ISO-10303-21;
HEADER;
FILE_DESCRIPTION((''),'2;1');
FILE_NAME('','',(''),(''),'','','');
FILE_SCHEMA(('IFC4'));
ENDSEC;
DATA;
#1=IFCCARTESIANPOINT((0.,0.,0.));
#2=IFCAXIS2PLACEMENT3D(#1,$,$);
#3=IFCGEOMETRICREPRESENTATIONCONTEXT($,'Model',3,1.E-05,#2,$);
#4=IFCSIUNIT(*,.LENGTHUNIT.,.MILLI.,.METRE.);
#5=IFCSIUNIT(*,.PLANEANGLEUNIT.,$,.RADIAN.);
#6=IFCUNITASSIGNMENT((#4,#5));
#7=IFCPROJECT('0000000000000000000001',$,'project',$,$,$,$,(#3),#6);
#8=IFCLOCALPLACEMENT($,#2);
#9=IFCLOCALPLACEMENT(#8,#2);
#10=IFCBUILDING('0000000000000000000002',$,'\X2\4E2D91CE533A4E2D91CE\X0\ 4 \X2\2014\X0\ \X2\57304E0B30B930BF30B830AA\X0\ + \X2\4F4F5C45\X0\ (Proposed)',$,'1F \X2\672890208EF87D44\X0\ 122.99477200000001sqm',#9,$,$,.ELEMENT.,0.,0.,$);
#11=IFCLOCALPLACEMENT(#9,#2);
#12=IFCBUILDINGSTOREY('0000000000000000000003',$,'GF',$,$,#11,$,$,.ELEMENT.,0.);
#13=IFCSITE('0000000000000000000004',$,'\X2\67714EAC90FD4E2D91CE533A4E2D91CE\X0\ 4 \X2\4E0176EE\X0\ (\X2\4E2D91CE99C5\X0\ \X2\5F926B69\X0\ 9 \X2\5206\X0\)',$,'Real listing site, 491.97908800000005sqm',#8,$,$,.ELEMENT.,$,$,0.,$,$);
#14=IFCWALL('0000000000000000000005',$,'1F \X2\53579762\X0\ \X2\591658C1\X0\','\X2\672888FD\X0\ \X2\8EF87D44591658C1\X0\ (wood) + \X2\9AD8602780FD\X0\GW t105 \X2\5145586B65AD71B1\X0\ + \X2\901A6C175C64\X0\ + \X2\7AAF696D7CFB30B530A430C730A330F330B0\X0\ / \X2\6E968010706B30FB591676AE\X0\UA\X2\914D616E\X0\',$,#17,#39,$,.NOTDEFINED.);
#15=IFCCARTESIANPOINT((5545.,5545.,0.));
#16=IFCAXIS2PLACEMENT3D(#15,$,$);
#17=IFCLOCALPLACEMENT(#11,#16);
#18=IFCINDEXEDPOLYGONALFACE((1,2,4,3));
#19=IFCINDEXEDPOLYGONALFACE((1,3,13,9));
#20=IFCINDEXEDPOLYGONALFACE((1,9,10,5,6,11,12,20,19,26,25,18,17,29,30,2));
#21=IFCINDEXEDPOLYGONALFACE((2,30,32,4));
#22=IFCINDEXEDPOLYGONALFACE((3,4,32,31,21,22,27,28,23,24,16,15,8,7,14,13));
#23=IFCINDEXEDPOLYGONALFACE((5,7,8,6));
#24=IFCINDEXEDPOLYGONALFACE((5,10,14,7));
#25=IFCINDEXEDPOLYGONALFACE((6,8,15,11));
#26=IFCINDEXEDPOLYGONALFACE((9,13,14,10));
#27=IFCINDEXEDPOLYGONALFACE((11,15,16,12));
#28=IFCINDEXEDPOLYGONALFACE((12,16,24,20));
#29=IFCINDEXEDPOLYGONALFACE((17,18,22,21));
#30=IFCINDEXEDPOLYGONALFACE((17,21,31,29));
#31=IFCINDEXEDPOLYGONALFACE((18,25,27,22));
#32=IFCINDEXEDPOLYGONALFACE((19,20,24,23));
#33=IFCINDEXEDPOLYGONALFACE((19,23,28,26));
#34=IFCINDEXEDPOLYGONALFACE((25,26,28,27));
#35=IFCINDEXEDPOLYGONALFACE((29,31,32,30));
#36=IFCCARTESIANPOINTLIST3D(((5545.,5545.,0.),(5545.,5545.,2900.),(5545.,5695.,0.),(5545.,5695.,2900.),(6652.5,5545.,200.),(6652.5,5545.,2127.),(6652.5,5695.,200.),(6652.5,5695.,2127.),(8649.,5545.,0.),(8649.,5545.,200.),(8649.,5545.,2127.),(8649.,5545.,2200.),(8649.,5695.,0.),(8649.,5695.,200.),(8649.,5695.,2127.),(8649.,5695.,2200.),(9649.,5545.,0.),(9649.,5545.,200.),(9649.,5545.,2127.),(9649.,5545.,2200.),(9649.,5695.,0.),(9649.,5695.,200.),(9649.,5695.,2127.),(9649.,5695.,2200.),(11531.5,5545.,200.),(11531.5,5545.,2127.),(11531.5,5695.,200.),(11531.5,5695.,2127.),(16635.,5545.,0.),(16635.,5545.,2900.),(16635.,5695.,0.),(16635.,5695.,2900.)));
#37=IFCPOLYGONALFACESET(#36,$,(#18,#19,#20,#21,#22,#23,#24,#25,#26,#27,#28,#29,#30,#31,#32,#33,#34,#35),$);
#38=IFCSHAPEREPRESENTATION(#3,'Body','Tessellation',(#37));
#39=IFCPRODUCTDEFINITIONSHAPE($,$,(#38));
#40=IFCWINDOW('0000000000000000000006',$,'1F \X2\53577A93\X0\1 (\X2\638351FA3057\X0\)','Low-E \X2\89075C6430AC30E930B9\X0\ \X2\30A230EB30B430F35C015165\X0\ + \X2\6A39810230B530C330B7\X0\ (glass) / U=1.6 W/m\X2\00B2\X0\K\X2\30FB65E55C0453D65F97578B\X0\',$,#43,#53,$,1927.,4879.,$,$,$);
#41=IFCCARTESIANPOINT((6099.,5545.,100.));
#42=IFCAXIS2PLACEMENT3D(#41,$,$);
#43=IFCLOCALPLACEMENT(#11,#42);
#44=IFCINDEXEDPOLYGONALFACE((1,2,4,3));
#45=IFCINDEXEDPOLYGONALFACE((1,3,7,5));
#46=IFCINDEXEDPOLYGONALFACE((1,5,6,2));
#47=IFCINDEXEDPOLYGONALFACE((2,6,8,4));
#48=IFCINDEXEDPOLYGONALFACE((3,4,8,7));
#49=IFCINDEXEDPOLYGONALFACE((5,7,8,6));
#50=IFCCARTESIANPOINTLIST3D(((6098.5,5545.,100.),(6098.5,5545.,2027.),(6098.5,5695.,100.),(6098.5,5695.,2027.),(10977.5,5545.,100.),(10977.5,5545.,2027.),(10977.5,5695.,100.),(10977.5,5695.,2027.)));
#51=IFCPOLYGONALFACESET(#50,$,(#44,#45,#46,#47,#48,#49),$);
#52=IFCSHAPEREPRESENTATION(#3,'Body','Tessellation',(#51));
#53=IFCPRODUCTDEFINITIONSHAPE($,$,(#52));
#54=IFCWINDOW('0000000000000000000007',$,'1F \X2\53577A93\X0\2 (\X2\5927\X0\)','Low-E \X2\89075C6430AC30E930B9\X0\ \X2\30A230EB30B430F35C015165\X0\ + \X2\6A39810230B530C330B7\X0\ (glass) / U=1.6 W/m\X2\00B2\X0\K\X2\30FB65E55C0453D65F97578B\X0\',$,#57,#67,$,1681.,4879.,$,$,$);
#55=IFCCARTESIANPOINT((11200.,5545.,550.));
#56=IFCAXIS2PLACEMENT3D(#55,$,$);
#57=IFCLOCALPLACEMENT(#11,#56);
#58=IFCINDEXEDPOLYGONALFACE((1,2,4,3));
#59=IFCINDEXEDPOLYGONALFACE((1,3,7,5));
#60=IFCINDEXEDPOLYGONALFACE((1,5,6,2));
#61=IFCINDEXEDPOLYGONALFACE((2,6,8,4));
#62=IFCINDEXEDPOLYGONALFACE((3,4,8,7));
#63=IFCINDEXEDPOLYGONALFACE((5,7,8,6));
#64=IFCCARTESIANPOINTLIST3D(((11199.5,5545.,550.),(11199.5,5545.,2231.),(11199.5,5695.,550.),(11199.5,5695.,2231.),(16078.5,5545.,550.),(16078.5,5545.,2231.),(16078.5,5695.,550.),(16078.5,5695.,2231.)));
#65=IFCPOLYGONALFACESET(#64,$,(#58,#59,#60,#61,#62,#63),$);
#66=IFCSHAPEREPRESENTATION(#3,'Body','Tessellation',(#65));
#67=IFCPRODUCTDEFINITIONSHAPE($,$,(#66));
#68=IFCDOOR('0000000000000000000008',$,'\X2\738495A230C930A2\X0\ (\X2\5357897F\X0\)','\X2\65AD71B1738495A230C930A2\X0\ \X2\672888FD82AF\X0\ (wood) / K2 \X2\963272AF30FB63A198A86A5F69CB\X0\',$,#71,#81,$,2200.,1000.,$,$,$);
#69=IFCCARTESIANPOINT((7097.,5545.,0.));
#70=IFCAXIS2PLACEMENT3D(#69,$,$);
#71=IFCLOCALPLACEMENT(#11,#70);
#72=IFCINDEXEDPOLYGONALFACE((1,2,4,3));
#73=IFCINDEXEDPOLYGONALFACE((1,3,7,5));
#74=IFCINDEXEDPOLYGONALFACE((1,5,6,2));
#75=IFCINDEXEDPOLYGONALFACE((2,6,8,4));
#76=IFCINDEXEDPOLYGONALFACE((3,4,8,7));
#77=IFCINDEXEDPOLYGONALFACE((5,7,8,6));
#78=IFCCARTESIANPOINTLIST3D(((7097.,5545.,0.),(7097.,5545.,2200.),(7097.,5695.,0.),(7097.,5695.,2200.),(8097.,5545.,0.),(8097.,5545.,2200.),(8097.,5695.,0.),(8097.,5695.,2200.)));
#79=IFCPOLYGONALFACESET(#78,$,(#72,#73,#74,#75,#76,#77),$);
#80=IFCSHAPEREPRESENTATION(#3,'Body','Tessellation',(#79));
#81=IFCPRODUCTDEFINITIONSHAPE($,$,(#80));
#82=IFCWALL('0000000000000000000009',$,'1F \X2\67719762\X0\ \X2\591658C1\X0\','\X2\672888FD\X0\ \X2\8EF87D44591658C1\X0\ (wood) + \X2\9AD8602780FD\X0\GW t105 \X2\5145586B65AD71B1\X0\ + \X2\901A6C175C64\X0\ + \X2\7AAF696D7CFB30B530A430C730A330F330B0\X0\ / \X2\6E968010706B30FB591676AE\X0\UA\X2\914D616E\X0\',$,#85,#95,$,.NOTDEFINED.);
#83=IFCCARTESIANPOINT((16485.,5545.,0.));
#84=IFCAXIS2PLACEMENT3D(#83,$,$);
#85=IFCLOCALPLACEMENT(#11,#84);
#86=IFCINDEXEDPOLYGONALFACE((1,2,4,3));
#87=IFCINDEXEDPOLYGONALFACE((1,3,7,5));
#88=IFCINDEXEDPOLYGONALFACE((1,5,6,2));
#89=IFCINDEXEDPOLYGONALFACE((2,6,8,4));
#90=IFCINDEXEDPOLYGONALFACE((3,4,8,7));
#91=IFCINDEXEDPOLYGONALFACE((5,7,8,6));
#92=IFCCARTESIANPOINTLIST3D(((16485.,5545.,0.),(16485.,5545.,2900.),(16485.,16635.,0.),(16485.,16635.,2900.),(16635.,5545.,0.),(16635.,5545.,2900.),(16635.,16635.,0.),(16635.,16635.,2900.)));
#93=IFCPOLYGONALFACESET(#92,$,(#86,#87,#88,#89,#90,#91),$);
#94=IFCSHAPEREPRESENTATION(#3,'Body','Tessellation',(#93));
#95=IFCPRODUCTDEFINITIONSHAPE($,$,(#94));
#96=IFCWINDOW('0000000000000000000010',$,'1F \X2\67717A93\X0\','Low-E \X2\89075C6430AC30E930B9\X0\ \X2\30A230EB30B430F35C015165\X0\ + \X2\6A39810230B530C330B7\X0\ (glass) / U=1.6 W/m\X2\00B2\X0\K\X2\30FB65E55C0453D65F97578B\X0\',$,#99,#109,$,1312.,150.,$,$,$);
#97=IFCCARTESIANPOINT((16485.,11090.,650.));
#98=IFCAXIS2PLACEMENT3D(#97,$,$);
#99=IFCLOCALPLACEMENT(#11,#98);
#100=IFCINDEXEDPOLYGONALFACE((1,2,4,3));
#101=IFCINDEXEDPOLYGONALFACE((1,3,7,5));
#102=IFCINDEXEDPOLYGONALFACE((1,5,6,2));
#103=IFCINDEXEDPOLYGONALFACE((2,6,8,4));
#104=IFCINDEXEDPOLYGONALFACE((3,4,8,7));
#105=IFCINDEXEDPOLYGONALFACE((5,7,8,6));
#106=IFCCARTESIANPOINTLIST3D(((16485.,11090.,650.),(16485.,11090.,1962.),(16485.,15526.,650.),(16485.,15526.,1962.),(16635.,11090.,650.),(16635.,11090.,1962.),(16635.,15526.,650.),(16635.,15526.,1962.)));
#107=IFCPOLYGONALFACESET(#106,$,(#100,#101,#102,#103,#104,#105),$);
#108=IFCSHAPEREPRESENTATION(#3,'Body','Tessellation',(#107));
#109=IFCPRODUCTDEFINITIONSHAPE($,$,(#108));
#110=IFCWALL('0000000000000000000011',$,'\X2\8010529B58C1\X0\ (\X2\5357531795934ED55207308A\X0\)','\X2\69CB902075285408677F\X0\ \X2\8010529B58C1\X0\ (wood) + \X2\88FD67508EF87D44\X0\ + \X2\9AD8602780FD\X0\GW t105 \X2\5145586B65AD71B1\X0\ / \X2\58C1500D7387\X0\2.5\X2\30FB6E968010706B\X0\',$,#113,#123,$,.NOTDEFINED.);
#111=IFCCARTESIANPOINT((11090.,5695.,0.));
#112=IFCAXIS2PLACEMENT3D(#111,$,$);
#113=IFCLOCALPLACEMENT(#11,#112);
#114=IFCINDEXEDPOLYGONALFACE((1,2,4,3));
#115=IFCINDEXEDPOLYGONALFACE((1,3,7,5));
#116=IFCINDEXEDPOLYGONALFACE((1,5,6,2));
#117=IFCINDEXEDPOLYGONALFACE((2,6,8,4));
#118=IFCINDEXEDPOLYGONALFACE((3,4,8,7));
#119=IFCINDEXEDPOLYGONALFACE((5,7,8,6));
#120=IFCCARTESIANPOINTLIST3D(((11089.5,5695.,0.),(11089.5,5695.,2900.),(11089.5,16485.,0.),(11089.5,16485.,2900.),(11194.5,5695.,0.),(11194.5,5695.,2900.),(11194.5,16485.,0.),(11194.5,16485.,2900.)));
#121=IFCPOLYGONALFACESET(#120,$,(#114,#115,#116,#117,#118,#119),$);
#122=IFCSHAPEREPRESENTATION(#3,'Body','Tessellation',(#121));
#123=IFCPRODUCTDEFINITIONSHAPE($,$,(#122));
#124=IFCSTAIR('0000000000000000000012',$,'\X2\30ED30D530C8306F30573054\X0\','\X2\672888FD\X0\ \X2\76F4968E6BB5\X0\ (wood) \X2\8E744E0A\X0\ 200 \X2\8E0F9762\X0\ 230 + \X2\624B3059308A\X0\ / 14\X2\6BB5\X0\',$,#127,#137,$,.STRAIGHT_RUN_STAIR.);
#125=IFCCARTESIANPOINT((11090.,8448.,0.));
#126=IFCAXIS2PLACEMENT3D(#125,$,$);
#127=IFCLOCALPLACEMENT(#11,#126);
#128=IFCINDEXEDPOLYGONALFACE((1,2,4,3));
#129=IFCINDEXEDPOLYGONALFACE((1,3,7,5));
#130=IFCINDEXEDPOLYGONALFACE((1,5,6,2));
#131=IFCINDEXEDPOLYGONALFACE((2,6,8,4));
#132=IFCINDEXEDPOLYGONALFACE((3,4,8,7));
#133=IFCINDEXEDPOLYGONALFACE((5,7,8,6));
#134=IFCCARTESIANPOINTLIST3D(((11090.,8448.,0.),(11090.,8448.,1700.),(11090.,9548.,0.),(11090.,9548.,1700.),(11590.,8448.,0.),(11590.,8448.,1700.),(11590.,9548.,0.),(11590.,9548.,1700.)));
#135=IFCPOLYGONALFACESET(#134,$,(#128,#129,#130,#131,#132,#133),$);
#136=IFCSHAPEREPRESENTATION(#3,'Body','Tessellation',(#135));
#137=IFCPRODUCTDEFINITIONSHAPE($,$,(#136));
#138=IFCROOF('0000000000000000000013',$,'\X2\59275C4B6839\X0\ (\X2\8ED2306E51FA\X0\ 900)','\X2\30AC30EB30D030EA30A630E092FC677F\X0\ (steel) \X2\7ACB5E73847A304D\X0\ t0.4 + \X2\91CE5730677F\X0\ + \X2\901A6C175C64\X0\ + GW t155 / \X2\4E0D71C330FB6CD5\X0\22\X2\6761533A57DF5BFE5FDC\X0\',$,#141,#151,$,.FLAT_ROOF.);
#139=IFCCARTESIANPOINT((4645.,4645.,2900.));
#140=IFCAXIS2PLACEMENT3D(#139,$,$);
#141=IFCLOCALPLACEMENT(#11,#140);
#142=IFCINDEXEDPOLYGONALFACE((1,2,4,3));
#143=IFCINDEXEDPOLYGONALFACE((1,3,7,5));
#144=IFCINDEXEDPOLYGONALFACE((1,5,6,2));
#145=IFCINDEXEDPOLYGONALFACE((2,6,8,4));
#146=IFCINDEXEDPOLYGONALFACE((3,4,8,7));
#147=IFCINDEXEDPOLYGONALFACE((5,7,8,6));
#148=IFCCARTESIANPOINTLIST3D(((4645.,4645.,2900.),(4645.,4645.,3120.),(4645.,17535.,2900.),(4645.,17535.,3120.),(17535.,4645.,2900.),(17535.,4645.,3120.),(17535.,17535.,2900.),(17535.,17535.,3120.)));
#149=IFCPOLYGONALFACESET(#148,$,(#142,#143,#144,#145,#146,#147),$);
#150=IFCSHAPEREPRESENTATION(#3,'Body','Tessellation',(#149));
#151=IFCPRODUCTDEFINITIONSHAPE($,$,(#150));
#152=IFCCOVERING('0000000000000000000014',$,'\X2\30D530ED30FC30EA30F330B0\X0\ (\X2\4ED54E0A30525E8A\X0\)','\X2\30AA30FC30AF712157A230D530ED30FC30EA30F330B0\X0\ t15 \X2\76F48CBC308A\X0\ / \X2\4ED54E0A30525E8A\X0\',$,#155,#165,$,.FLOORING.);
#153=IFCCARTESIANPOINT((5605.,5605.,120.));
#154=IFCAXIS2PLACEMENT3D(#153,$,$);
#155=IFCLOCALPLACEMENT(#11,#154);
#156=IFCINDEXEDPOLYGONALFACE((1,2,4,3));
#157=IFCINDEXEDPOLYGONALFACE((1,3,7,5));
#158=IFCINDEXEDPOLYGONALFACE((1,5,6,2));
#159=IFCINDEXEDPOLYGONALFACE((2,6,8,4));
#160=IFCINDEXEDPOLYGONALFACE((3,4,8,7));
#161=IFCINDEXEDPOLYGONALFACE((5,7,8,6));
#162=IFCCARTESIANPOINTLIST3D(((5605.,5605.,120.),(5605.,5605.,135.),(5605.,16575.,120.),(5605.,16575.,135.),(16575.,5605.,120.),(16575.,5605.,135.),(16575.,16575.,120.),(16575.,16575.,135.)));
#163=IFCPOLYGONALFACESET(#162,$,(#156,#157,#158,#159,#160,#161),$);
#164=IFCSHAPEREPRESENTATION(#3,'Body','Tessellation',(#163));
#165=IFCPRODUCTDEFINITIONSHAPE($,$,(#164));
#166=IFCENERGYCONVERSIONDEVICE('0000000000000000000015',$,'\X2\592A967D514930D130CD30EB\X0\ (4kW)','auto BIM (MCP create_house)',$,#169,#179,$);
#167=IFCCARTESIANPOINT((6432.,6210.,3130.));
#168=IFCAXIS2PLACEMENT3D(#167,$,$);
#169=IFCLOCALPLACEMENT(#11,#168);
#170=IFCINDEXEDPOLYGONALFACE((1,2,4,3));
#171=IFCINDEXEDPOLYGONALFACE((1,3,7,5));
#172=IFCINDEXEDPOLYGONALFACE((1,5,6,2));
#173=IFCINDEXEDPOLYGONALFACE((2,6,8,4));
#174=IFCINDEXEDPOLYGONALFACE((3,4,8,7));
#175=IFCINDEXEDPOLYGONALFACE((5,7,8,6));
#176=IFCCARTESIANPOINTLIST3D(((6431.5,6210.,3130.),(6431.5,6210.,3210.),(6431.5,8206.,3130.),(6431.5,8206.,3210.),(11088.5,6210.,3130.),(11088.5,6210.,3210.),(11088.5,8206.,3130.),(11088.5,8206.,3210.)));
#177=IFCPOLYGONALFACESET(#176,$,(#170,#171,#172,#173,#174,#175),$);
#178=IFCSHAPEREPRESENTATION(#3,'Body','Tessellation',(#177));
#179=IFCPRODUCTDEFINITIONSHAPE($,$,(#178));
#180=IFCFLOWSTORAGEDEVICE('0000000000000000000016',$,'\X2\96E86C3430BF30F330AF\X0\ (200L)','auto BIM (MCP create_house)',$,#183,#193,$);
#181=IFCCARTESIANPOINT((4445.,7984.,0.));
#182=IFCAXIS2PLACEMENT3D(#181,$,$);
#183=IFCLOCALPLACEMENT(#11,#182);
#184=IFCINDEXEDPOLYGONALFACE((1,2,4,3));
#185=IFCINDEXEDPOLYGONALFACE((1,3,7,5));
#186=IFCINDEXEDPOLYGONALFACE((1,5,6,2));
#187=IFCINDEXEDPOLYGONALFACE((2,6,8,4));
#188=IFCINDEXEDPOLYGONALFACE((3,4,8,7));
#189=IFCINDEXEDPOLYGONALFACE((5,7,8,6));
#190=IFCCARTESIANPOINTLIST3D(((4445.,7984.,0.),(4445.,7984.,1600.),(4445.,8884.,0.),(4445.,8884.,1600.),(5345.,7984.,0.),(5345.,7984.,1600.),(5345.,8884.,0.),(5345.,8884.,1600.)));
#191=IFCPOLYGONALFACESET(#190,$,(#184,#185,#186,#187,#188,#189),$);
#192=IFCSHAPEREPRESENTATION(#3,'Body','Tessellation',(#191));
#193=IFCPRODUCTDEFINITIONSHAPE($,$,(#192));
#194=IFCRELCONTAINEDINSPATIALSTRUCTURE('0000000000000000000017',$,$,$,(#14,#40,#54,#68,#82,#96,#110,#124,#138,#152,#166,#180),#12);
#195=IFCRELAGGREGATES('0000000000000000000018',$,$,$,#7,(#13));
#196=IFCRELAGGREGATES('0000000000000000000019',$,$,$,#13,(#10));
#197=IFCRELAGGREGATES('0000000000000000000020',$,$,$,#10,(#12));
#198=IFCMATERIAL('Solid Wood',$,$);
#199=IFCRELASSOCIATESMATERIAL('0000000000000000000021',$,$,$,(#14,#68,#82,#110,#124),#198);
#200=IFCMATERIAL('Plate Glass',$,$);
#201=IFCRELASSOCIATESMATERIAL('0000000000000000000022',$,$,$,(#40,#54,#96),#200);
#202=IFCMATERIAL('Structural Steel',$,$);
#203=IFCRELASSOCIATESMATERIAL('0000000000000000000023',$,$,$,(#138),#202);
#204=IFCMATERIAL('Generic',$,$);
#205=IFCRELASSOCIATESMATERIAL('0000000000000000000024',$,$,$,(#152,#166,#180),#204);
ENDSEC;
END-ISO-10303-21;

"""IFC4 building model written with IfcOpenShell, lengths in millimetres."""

from ifc_helpers import new_model, si_unit, frame, frame_2d, origin, place, context, project, spatial, rectangle, extrude, material, element, fill, save


model = new_model("IFC4")

# Units and contexts
model_context = context("Model", 3, precision=1e-05, world=origin())
ifc_project = project(units=[si_unit("LENGTHUNIT", "METRE", prefix="MILLI"), si_unit("PLANEANGLEUNIT", "RADIAN")], contexts=[model_context])

# Site, building, storey
site_placement = place(None, origin())
site = spatial("IfcSite", under=ifc_project, at=site_placement, Name="東京都中野区中野 4 丁目 (中野駅 徒歩 9 分)", ObjectType="Real listing site, 491.97908800000005sqm", CompositionType="ELEMENT", RefElevation=0.0)
building_placement = place(site_placement, origin())
building = spatial("IfcBuilding", under=site, at=building_placement, Name="中野区中野 4 — 地下スタジオ + 住居 (Proposed)", ObjectType="1F 木造軸組 122.99477200000001sqm", CompositionType="ELEMENT", ElevationOfRefHeight=0.0, ElevationOfTerrain=0.0)
storey_placement = place(building_placement, origin())
storey = spatial("IfcBuildingStorey", under=building, at=storey_placement, Name="GF", CompositionType="ELEMENT", Elevation=0.0)

# Shared definitions
ifc_material_1 = material(Name="Solid Wood")

# Wall, openings, windows, door
wall_1_placement = place(storey_placement, frame((5545.0, 5545.0, 0.0)))
wall_1 = element("IfcWall", 1, at=wall_1_placement, inside=storey, material=ifc_material_1, Name="1F 南面 外壁", Description="木製 軸組外壁 (wood) + 高性能GW t105 充填断熱 + 通気層 + 窯業系サイディング / 準耐火・外皮UA配慮", PredefinedType="NOTDEFINED", context=model_context, shape_type="SweptSolid", body=[
    extrude(rectangle(XDim=11090.0, YDim=150.0, at=frame_2d((5545.0, 75.0))), frame((5545.0, 5545.0, 0.0)), (0.0, 0.0, 1.0), 2900.0),
])
opening_1_placement = place(storey_placement, frame((6099.0, 5545.0, 100.0)))
opening_1 = element("IfcOpeningElement", 2, at=opening_1_placement, cuts=wall_1, PredefinedType="NOTDEFINED", context=model_context, shape_type="SweptSolid", body=[
    extrude(rectangle(XDim=4879.0, YDim=150.0, at=frame_2d((2439.0, 75.0))), frame((6099.0, 5545.0, 100.0)), (0.0, 0.0, 1.0), 1927.0),
])
opening_2_placement = place(storey_placement, frame((11200.0, 5545.0, 550.0)))
opening_2 = element("IfcOpeningElement", 3, at=opening_2_placement, cuts=wall_1, PredefinedType="NOTDEFINED", context=model_context, shape_type="SweptSolid", body=[
    extrude(rectangle(XDim=4879.0, YDim=150.0, at=frame_2d((2439.0, 75.0))), frame((11200.0, 5545.0, 550.0)), (0.0, 0.0, 1.0), 1681.0),
])
opening_3_placement = place(storey_placement, frame((7097.0, 5545.0, 0.0)))
opening_3 = element("IfcOpeningElement", 4, at=opening_3_placement, cuts=wall_1, PredefinedType="NOTDEFINED", context=model_context, shape_type="SweptSolid", body=[
    extrude(rectangle(XDim=1000.0, YDim=150.0, at=frame_2d((500.0, 75.0))), frame((7097.0, 5545.0, 0.0)), (0.0, 0.0, 1.0), 2200.0),
])
ifc_material_2 = material(Name="Plate Glass")
window_1_placement = place(storey_placement, frame((6099.0, 5545.0, 100.0)))
window_1 = element("IfcWindow", 5, at=window_1_placement, inside=storey, material=ifc_material_2, Name="1F 南窓1 (掃出し)", Description="Low-E 複層ガラス アルゴン封入 + 樹脂サッシ (glass) / U=1.6 W/m²K・日射取得型", OverallHeight=1927.0, OverallWidth=4879.0, context=model_context, shape_type="SweptSolid", body=[
    extrude(rectangle(XDim=4879.0, YDim=150.0, at=frame_2d((2439.0, 75.0))), frame((6099.0, 5545.0, 100.0)), (0.0, 0.0, 1.0), 1927.0),
])
fill(opening_1, window_1)
window_2_placement = place(storey_placement, frame((11200.0, 5545.0, 550.0)))
window_2 = element("IfcWindow", 6, at=window_2_placement, inside=storey, material=ifc_material_2, Name="1F 南窓2 (大)", Description="Low-E 複層ガラス アルゴン封入 + 樹脂サッシ (glass) / U=1.6 W/m²K・日射取得型", OverallHeight=1681.0, OverallWidth=4879.0, context=model_context, shape_type="SweptSolid", body=[
    extrude(rectangle(XDim=4879.0, YDim=150.0, at=frame_2d((2439.0, 75.0))), frame((11200.0, 5545.0, 550.0)), (0.0, 0.0, 1.0), 1681.0),
])
fill(opening_2, window_2)
door_placement = place(storey_placement, frame((7097.0, 5545.0, 0.0)))
door = element("IfcDoor", 7, at=door_placement, inside=storey, material=ifc_material_1, Name="玄関ドア (南西)", Description="断熱玄関ドア 木製芯 (wood) / K2 防犯・採風機構", OverallHeight=2200.0, OverallWidth=1000.0, context=model_context, shape_type="SweptSolid", body=[
    extrude(rectangle(XDim=1000.0, YDim=150.0, at=frame_2d((500.0, 75.0))), frame((7097.0, 5545.0, 0.0)), (0.0, 0.0, 1.0), 2200.0),
])
fill(opening_3, door)

# Wall, opening, window
wall_2_placement = place(storey_placement, frame((16485.0, 5545.0, 0.0)))
wall_2 = element("IfcWall", 8, at=wall_2_placement, inside=storey, material=ifc_material_1, Name="1F 東面 外壁", Description="木製 軸組外壁 (wood) + 高性能GW t105 充填断熱 + 通気層 + 窯業系サイディング / 準耐火・外皮UA配慮", PredefinedType="NOTDEFINED", context=model_context, shape_type="SweptSolid", body=[
    extrude(rectangle(XDim=150.0, YDim=11090.0, at=frame_2d((75.0, 5545.0))), frame((16485.0, 5545.0, 0.0)), (0.0, 0.0, 1.0), 2900.0),
])
opening_4_placement = place(storey_placement, frame((16485.0, 11090.0, 650.0)))
opening_4 = element("IfcOpeningElement", 9, at=opening_4_placement, cuts=wall_2, PredefinedType="NOTDEFINED", context=model_context, shape_type="SweptSolid", body=[
    extrude(rectangle(XDim=150.0, YDim=4436.0, at=frame_2d((75.0, 2218.0))), frame((16485.0, 11090.0, 650.0)), (0.0, 0.0, 1.0), 1312.0),
])
window_3_placement = place(storey_placement, frame((16485.0, 11090.0, 650.0)))
window_3 = element("IfcWindow", 10, at=window_3_placement, inside=storey, material=ifc_material_2, Name="1F 東窓", Description="Low-E 複層ガラス アルゴン封入 + 樹脂サッシ (glass) / U=1.6 W/m²K・日射取得型", OverallHeight=1312.0, OverallWidth=150.0, context=model_context, shape_type="SweptSolid", body=[
    extrude(rectangle(XDim=150.0, YDim=4436.0, at=frame_2d((75.0, 2218.0))), frame((16485.0, 11090.0, 650.0)), (0.0, 0.0, 1.0), 1312.0),
])
fill(opening_4, window_3)

# Wall
wall_3_placement = place(storey_placement, frame((11090.0, 5695.0, 0.0)))
element("IfcWall", 11, at=wall_3_placement, inside=storey, material=ifc_material_1, Name="耐力壁 (南北間仕切り)", Description="構造用合板 耐力壁 (wood) + 製材軸組 + 高性能GW t105 充填断熱 / 壁倍率2.5・準耐火", PredefinedType="NOTDEFINED", context=model_context, shape_type="SweptSolid", body=[
    extrude(rectangle(XDim=105.0, YDim=10790.0, at=frame_2d((52.0, 5395.0))), frame((11090.0, 5695.0, 0.0)), (0.0, 0.0, 1.0), 2900.0),
])

# Stair
stair_placement = place(storey_placement, frame((11090.0, 8448.0, 0.0)))
element("IfcStair", 12, at=stair_placement, inside=storey, material=ifc_material_1, Name="ロフトはしご", Description="木製 直階段 (wood) 蹴上 200 踏面 230 + 手すり / 14段", PredefinedType="STRAIGHT_RUN_STAIR", context=model_context, shape_type="SweptSolid", body=[
    extrude(rectangle(XDim=500.0, YDim=1100.0, at=frame_2d((250.0, 550.0))), frame((11090.0, 8448.0, 0.0)), (0.0, 0.0, 1.0), 1700.0),
])

# Roof
ifc_material_3 = material(Name="Structural Steel")
roof_placement = place(storey_placement, frame((4645.0, 4645.0, 2900.0)))
element("IfcRoof", 13, at=roof_placement, inside=storey, material=ifc_material_3, Name="大屋根 (軒の出 900)", Description="ガルバリウム鋼板 (steel) 立平葺き t0.4 + 野地板 + 通気層 + GW t155 / 不燃・法22条区域対応", PredefinedType="FLAT_ROOF", context=model_context, shape_type="SweptSolid", body=[
    extrude(rectangle(XDim=12890.0, YDim=12890.0, at=frame_2d((6445.0, 6445.0))), frame((4645.0, 4645.0, 2900.0)), (0.0, 0.0, 1.0), 220.0),
])

# Covering
ifc_material_4 = material(Name="Generic")
covering_placement = place(storey_placement, frame((5605.0, 5605.0, 120.0)))
element("IfcCovering", 14, at=covering_placement, inside=storey, material=ifc_material_4, Name="フローリング (仕上げ床)", Description="オーク無垢フローリング t15 直貼り / 仕上げ床", PredefinedType="FLOORING", context=model_context, shape_type="SweptSolid", body=[
    extrude(rectangle(XDim=10970.0, YDim=10970.0, at=frame_2d((5485.0, 5485.0))), frame((5605.0, 5605.0, 120.0)), (0.0, 0.0, 1.0), 15.0),
])

# Energy conversion device
energy_conversion_device_placement = place(storey_placement, frame((6432.0, 6210.0, 3130.0)))
element("IfcEnergyConversionDevice", 15, at=energy_conversion_device_placement, inside=storey, material=ifc_material_4, Name="太陽光パネル (4kW)", Description="auto BIM (MCP create_house)", context=model_context, shape_type="SweptSolid", body=[
    extrude(rectangle(XDim=4657.0, YDim=1996.0, at=frame_2d((2328.0, 998.0))), frame((6432.0, 6210.0, 3130.0)), (0.0, 0.0, 1.0), 80.0),
])

# Flow storage device
flow_storage_device_placement = place(storey_placement, frame((4445.0, 7984.0, 0.0)))
element("IfcFlowStorageDevice", 16, at=flow_storage_device_placement, inside=storey, material=ifc_material_4, Name="雨水タンク (200L)", Description="auto BIM (MCP create_house)", context=model_context, shape_type="SweptSolid", body=[
    extrude(rectangle(XDim=900.0, YDim=900.0, at=frame_2d((450.0, 450.0))), frame((4445.0, 7984.0, 0.0)), (0.0, 0.0, 1.0), 1600.0),
])

save(model, "model.ifc")
